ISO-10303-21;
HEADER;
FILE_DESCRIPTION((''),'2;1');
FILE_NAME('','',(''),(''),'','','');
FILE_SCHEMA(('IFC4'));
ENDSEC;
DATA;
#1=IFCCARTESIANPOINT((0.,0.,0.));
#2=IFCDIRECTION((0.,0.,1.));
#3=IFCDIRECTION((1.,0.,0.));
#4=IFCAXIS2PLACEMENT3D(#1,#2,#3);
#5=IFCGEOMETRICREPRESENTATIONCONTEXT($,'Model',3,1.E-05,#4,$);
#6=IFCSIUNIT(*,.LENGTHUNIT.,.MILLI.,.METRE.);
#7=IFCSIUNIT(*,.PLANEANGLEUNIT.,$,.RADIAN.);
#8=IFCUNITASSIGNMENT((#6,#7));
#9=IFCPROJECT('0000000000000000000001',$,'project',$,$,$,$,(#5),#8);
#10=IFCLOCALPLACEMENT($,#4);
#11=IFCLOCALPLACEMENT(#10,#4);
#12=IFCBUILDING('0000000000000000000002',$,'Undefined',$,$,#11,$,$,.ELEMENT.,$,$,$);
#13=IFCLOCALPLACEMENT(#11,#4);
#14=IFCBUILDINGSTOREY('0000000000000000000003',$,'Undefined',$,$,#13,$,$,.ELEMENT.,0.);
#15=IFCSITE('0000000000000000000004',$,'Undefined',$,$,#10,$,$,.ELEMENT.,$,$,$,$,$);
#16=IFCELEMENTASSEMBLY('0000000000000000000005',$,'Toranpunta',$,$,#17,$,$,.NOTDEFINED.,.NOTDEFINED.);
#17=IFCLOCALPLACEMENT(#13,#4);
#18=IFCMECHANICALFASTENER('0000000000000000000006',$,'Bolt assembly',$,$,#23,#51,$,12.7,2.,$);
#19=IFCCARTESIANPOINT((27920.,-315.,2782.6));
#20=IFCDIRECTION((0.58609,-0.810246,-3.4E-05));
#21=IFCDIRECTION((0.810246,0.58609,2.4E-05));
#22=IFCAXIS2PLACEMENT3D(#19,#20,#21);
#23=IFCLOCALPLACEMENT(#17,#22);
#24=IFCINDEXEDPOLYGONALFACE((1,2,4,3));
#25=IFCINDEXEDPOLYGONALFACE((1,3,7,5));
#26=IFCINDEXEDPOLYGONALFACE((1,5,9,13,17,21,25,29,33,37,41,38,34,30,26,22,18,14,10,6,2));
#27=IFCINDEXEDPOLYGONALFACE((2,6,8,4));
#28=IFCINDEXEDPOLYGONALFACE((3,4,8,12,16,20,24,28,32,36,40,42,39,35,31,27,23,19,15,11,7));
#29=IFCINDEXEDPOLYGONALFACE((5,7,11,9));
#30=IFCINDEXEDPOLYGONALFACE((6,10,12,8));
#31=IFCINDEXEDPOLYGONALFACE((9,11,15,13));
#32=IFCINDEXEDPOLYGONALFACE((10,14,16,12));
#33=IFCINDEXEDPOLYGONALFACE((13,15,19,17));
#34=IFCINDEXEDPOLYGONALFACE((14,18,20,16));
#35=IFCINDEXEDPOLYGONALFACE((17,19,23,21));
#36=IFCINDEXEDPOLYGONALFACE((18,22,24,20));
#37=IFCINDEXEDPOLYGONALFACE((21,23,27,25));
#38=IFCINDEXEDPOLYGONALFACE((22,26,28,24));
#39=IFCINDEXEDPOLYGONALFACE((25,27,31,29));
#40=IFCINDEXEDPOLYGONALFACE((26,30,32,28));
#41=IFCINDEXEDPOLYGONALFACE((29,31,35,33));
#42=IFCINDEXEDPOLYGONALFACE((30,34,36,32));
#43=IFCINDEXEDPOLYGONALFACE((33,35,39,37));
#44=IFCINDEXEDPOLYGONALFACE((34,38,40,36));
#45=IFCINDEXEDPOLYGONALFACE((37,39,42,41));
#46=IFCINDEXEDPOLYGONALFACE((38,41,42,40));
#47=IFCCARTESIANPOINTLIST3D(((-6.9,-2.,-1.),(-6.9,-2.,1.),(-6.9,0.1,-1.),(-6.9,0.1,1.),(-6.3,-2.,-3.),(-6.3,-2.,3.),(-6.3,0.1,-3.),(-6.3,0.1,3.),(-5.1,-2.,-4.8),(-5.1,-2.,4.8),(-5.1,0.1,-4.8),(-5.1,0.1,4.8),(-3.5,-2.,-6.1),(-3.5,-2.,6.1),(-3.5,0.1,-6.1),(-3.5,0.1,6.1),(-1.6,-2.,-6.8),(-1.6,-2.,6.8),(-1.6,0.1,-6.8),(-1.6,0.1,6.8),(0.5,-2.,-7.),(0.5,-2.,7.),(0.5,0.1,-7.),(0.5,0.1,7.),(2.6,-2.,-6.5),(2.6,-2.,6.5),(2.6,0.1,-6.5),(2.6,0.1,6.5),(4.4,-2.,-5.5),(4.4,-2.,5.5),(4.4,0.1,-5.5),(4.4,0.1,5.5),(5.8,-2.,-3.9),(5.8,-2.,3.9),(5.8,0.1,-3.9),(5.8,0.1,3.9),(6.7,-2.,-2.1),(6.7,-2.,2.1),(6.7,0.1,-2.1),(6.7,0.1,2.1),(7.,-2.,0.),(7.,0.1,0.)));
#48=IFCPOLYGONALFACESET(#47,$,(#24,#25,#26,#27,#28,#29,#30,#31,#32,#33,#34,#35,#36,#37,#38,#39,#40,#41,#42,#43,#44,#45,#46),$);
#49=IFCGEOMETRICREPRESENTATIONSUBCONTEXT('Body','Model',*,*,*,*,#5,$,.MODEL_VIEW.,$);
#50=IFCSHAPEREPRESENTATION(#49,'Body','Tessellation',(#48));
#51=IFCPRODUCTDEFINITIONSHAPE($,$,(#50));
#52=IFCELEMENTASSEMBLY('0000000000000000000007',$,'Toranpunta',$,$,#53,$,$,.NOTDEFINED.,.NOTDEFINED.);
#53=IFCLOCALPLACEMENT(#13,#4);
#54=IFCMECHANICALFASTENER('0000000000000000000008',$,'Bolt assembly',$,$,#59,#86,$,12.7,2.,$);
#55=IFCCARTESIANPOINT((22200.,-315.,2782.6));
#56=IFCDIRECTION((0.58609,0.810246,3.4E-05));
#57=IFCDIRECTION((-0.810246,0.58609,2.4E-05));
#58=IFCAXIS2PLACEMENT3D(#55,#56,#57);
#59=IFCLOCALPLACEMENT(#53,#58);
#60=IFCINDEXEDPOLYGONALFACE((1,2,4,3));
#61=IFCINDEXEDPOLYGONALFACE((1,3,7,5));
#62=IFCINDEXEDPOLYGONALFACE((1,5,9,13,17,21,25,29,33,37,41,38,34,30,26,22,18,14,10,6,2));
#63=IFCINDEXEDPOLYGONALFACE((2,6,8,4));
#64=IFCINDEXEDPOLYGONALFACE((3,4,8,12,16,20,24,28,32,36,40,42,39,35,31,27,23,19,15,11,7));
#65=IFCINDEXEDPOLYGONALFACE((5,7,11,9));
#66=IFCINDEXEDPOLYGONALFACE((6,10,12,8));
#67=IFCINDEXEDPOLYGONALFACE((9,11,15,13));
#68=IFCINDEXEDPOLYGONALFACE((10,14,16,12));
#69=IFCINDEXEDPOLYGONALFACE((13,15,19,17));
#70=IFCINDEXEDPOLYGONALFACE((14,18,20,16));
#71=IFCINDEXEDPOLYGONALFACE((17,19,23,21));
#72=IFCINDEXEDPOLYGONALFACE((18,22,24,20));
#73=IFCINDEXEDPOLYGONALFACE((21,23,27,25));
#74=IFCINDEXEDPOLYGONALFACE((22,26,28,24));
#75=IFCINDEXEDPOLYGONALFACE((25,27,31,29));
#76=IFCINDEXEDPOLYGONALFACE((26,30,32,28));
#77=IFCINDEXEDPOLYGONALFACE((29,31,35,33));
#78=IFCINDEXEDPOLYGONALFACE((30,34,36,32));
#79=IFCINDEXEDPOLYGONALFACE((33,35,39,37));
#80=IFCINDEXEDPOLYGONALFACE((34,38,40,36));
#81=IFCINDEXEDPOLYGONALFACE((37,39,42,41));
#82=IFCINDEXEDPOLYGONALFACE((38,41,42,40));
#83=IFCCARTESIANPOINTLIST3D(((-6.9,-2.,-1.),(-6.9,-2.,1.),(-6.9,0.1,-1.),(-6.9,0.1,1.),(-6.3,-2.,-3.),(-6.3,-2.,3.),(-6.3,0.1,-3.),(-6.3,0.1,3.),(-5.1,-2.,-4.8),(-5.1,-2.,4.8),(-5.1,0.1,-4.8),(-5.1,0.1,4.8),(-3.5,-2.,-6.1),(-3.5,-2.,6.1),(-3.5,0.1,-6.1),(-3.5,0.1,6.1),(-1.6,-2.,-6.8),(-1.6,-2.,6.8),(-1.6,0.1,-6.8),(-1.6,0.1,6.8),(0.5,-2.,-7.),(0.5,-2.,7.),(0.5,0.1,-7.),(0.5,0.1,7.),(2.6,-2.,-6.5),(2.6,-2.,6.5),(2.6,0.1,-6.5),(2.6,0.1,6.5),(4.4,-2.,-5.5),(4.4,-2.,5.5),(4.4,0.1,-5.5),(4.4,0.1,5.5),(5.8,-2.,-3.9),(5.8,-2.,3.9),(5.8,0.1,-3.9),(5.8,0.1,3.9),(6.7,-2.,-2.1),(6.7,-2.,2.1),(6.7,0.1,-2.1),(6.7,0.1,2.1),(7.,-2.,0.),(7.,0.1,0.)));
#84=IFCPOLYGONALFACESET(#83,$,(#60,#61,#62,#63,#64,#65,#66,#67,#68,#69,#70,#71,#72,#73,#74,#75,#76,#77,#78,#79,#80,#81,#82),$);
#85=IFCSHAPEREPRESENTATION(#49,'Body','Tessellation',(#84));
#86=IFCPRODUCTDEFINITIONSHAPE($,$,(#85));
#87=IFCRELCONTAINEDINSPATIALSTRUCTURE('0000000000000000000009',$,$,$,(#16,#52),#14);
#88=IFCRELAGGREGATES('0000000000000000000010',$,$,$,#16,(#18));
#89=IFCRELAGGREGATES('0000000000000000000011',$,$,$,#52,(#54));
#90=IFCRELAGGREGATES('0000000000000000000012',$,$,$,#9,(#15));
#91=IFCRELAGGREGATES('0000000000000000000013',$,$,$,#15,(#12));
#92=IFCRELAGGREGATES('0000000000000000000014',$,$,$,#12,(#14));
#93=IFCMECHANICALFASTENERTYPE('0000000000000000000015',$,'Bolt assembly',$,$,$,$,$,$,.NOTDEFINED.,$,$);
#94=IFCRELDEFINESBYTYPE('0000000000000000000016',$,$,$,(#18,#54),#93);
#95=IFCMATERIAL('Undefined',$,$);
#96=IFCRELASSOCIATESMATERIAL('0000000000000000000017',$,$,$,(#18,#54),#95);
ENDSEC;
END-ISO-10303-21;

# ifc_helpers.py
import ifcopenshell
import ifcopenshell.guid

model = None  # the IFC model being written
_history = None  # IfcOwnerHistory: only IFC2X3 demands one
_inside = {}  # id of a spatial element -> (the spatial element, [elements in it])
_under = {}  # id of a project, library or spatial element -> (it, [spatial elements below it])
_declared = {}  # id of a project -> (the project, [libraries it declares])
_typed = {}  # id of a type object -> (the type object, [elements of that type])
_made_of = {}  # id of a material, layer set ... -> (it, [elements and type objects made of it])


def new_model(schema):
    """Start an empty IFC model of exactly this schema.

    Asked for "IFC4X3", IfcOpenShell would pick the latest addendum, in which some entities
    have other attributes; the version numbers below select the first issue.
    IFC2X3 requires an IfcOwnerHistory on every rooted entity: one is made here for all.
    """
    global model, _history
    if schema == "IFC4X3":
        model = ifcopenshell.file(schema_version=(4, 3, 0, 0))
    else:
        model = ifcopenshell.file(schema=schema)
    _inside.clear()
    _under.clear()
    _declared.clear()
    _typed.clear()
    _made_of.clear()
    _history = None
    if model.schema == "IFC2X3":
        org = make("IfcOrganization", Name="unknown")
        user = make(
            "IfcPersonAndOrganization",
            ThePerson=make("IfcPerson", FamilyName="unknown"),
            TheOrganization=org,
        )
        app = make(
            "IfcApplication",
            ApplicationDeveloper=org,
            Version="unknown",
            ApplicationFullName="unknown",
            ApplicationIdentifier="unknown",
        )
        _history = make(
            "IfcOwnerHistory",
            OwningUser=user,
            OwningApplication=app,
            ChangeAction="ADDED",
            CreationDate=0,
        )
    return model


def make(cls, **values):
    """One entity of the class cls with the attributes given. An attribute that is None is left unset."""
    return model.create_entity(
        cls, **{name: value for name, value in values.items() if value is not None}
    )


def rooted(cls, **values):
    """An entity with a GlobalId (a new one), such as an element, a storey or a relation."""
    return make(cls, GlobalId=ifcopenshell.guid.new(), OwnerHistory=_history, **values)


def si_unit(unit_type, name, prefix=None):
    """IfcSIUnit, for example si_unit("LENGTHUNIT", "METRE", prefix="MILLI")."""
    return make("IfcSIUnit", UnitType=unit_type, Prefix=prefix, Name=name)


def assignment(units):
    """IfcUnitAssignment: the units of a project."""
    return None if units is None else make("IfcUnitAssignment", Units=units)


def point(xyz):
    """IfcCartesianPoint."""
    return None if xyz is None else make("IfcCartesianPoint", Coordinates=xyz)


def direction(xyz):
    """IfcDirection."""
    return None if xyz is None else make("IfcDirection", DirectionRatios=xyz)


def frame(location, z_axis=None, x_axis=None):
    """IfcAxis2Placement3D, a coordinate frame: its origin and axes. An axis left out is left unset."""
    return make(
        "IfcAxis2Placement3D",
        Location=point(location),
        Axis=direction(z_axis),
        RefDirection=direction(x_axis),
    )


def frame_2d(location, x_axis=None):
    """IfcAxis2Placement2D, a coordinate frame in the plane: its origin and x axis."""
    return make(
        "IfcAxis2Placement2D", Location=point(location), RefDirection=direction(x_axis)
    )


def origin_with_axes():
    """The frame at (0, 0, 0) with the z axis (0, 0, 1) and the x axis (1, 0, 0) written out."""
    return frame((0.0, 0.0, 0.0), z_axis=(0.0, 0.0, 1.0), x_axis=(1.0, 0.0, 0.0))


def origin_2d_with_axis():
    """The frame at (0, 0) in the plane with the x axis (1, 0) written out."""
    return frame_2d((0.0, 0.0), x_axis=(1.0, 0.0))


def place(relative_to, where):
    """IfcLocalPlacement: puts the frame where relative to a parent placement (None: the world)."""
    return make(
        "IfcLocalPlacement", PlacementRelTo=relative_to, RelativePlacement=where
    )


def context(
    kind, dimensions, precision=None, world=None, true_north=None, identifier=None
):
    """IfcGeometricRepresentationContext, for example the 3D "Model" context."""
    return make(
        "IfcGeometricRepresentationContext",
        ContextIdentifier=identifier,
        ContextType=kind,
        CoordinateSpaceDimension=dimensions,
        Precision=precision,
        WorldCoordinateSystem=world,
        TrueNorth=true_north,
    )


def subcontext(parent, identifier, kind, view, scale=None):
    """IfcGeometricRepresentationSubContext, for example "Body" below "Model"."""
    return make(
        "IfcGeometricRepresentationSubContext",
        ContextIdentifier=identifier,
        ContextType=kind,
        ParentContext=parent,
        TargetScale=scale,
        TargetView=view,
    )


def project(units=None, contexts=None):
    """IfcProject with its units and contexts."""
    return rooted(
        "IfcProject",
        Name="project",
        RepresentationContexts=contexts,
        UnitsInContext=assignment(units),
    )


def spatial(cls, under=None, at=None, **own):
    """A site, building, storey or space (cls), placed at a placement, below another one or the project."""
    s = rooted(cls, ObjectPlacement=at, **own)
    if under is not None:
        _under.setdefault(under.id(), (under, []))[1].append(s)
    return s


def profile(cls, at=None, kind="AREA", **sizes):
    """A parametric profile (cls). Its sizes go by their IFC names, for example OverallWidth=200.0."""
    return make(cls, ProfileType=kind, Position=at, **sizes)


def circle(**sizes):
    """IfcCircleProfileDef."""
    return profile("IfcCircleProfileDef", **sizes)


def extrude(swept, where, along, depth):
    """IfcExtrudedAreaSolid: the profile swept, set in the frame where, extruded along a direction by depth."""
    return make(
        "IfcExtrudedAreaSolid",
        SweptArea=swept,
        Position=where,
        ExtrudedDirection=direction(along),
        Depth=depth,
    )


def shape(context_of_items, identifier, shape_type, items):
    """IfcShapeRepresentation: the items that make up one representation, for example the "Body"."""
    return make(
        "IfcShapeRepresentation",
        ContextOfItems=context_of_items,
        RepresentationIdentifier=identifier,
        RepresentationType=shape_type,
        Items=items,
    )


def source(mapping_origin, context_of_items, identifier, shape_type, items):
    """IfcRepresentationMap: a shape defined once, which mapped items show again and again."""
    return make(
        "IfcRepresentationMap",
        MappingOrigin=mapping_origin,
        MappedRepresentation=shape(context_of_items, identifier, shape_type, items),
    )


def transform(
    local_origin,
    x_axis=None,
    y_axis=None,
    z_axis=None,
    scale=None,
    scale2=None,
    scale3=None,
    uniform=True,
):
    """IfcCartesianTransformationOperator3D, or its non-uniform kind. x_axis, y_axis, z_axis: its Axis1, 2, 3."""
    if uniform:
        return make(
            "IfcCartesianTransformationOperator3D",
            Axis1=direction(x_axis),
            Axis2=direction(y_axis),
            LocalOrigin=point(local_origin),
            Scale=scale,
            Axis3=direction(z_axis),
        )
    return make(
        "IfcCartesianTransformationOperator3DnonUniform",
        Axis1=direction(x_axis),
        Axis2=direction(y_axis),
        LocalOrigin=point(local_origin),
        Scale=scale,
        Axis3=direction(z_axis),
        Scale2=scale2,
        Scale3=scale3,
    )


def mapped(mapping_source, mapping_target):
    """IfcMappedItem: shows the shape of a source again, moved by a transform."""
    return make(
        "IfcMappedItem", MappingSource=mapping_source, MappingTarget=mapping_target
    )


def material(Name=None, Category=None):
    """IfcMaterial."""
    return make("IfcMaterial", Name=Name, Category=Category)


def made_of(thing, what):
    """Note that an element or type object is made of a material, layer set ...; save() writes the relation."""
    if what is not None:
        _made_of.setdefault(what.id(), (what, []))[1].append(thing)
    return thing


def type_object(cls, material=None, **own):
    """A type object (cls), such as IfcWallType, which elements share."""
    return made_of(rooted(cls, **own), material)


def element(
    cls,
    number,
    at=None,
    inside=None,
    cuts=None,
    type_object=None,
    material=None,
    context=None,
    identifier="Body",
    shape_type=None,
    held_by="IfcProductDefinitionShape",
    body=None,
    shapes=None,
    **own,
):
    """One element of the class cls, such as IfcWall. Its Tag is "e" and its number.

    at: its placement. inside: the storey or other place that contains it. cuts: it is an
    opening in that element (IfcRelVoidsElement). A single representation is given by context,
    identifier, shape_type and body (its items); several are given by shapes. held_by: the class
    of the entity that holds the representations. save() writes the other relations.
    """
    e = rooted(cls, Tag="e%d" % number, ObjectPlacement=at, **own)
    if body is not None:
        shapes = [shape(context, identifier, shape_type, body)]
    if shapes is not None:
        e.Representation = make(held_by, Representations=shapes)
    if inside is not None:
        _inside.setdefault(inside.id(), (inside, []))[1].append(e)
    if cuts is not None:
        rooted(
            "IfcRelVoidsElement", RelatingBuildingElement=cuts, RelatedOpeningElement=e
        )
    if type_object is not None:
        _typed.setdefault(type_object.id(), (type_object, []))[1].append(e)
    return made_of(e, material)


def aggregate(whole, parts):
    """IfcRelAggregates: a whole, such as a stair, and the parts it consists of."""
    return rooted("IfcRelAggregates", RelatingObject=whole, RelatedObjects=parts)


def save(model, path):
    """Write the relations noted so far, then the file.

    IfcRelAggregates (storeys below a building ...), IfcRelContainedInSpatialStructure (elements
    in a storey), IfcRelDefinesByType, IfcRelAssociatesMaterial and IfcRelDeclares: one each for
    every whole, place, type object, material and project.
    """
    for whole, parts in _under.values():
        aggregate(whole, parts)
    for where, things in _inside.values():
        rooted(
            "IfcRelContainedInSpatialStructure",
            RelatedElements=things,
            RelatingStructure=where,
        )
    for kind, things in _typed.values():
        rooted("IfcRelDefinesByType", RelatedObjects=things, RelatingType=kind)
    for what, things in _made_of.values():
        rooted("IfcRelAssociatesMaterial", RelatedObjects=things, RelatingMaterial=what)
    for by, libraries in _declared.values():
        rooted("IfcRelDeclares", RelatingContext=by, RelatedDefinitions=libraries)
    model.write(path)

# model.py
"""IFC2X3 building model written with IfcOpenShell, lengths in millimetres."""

from ifc_helpers import new_model, si_unit, frame, origin_with_axes, origin_2d_with_axis, place, context, subcontext, project, spatial, circle, extrude, source, transform, mapped, material, type_object, element, aggregate, save


model = new_model("IFC2X3")

# Units and contexts
model_context = context("Model", 3, precision=1e-05, world=origin_with_axes())
body_context = subcontext(model_context, "Body", "Model", "MODEL_VIEW")
ifc_project = project(units=[si_unit("LENGTHUNIT", "METRE", prefix="MILLI"), si_unit("PLANEANGLEUNIT", "RADIAN")], contexts=[model_context])

# Site, building, storey
site_placement = place(None, origin_with_axes())
site = spatial("IfcSite", under=ifc_project, at=site_placement, Name="Undefined", CompositionType="ELEMENT")
building_placement = place(site_placement, origin_with_axes())
building = spatial("IfcBuilding", under=site, at=building_placement, Name="Undefined", CompositionType="ELEMENT")
storey_placement = place(building_placement, origin_with_axes())
storey = spatial("IfcBuildingStorey", under=building, at=storey_placement, Name="Undefined", CompositionType="ELEMENT", Elevation=0.0)

# Element assemblies, mechanical fasteners
assembly_1_placement = place(storey_placement, origin_with_axes())
assembly_1 = element("IfcElementAssembly", 1, at=assembly_1_placement, inside=storey, Name="Toranpunta", AssemblyPlace="NOTDEFINED", PredefinedType="NOTDEFINED")
ifc_material_1 = material(Name="Undefined")
mechanical_fastener_type = type_object("IfcMechanicalFastenerType", Name="Bolt assembly")
shared_shape_1 = source(origin_with_axes(), body_context, "Body", "SweptSolid", [
    extrude(circle(Radius=7.0, at=origin_2d_with_axis()), frame((0.0, -2.0, 0.0), z_axis=(0.0, 1.0, 0.0), x_axis=(1.0, 0.0, 0.0)), (0.0, 0.0, 1.0), 2.1),
])
mechanical_fastener_1_placement = place(assembly_1_placement, frame((27920.0, -315.0, 2782.6), z_axis=(0.58609, -0.810246, -0.000034), x_axis=(0.810246, 0.58609, 0.000024)))
mechanical_fastener_1 = element("IfcMechanicalFastener", 2, at=mechanical_fastener_1_placement, type_object=mechanical_fastener_type, material=ifc_material_1, Name="Bolt assembly", NominalDiameter=12.7, NominalLength=2.0, context=body_context, shape_type="MappedRepresentation", body=[
    mapped(shared_shape_1, transform((0.0, 0.0, 0.0))),
])
aggregate(assembly_1, [mechanical_fastener_1])
assembly_2_placement = place(storey_placement, origin_with_axes())
assembly_2 = element("IfcElementAssembly", 3, at=assembly_2_placement, inside=storey, Name="Toranpunta", AssemblyPlace="NOTDEFINED", PredefinedType="NOTDEFINED")
mechanical_fastener_2_placement = place(assembly_2_placement, frame((22200.0, -315.0, 2782.6), z_axis=(0.58609, 0.810246, 0.000034), x_axis=(-0.810246, 0.58609, 0.000024)))
mechanical_fastener_2 = element("IfcMechanicalFastener", 4, at=mechanical_fastener_2_placement, type_object=mechanical_fastener_type, material=ifc_material_1, Name="Bolt assembly", NominalDiameter=12.7, NominalLength=2.0, context=body_context, shape_type="MappedRepresentation", body=[
    mapped(shared_shape_1, transform((0.0, 0.0, 0.0))),
])
aggregate(assembly_2, [mechanical_fastener_2])

save(model, "model.ifc")
